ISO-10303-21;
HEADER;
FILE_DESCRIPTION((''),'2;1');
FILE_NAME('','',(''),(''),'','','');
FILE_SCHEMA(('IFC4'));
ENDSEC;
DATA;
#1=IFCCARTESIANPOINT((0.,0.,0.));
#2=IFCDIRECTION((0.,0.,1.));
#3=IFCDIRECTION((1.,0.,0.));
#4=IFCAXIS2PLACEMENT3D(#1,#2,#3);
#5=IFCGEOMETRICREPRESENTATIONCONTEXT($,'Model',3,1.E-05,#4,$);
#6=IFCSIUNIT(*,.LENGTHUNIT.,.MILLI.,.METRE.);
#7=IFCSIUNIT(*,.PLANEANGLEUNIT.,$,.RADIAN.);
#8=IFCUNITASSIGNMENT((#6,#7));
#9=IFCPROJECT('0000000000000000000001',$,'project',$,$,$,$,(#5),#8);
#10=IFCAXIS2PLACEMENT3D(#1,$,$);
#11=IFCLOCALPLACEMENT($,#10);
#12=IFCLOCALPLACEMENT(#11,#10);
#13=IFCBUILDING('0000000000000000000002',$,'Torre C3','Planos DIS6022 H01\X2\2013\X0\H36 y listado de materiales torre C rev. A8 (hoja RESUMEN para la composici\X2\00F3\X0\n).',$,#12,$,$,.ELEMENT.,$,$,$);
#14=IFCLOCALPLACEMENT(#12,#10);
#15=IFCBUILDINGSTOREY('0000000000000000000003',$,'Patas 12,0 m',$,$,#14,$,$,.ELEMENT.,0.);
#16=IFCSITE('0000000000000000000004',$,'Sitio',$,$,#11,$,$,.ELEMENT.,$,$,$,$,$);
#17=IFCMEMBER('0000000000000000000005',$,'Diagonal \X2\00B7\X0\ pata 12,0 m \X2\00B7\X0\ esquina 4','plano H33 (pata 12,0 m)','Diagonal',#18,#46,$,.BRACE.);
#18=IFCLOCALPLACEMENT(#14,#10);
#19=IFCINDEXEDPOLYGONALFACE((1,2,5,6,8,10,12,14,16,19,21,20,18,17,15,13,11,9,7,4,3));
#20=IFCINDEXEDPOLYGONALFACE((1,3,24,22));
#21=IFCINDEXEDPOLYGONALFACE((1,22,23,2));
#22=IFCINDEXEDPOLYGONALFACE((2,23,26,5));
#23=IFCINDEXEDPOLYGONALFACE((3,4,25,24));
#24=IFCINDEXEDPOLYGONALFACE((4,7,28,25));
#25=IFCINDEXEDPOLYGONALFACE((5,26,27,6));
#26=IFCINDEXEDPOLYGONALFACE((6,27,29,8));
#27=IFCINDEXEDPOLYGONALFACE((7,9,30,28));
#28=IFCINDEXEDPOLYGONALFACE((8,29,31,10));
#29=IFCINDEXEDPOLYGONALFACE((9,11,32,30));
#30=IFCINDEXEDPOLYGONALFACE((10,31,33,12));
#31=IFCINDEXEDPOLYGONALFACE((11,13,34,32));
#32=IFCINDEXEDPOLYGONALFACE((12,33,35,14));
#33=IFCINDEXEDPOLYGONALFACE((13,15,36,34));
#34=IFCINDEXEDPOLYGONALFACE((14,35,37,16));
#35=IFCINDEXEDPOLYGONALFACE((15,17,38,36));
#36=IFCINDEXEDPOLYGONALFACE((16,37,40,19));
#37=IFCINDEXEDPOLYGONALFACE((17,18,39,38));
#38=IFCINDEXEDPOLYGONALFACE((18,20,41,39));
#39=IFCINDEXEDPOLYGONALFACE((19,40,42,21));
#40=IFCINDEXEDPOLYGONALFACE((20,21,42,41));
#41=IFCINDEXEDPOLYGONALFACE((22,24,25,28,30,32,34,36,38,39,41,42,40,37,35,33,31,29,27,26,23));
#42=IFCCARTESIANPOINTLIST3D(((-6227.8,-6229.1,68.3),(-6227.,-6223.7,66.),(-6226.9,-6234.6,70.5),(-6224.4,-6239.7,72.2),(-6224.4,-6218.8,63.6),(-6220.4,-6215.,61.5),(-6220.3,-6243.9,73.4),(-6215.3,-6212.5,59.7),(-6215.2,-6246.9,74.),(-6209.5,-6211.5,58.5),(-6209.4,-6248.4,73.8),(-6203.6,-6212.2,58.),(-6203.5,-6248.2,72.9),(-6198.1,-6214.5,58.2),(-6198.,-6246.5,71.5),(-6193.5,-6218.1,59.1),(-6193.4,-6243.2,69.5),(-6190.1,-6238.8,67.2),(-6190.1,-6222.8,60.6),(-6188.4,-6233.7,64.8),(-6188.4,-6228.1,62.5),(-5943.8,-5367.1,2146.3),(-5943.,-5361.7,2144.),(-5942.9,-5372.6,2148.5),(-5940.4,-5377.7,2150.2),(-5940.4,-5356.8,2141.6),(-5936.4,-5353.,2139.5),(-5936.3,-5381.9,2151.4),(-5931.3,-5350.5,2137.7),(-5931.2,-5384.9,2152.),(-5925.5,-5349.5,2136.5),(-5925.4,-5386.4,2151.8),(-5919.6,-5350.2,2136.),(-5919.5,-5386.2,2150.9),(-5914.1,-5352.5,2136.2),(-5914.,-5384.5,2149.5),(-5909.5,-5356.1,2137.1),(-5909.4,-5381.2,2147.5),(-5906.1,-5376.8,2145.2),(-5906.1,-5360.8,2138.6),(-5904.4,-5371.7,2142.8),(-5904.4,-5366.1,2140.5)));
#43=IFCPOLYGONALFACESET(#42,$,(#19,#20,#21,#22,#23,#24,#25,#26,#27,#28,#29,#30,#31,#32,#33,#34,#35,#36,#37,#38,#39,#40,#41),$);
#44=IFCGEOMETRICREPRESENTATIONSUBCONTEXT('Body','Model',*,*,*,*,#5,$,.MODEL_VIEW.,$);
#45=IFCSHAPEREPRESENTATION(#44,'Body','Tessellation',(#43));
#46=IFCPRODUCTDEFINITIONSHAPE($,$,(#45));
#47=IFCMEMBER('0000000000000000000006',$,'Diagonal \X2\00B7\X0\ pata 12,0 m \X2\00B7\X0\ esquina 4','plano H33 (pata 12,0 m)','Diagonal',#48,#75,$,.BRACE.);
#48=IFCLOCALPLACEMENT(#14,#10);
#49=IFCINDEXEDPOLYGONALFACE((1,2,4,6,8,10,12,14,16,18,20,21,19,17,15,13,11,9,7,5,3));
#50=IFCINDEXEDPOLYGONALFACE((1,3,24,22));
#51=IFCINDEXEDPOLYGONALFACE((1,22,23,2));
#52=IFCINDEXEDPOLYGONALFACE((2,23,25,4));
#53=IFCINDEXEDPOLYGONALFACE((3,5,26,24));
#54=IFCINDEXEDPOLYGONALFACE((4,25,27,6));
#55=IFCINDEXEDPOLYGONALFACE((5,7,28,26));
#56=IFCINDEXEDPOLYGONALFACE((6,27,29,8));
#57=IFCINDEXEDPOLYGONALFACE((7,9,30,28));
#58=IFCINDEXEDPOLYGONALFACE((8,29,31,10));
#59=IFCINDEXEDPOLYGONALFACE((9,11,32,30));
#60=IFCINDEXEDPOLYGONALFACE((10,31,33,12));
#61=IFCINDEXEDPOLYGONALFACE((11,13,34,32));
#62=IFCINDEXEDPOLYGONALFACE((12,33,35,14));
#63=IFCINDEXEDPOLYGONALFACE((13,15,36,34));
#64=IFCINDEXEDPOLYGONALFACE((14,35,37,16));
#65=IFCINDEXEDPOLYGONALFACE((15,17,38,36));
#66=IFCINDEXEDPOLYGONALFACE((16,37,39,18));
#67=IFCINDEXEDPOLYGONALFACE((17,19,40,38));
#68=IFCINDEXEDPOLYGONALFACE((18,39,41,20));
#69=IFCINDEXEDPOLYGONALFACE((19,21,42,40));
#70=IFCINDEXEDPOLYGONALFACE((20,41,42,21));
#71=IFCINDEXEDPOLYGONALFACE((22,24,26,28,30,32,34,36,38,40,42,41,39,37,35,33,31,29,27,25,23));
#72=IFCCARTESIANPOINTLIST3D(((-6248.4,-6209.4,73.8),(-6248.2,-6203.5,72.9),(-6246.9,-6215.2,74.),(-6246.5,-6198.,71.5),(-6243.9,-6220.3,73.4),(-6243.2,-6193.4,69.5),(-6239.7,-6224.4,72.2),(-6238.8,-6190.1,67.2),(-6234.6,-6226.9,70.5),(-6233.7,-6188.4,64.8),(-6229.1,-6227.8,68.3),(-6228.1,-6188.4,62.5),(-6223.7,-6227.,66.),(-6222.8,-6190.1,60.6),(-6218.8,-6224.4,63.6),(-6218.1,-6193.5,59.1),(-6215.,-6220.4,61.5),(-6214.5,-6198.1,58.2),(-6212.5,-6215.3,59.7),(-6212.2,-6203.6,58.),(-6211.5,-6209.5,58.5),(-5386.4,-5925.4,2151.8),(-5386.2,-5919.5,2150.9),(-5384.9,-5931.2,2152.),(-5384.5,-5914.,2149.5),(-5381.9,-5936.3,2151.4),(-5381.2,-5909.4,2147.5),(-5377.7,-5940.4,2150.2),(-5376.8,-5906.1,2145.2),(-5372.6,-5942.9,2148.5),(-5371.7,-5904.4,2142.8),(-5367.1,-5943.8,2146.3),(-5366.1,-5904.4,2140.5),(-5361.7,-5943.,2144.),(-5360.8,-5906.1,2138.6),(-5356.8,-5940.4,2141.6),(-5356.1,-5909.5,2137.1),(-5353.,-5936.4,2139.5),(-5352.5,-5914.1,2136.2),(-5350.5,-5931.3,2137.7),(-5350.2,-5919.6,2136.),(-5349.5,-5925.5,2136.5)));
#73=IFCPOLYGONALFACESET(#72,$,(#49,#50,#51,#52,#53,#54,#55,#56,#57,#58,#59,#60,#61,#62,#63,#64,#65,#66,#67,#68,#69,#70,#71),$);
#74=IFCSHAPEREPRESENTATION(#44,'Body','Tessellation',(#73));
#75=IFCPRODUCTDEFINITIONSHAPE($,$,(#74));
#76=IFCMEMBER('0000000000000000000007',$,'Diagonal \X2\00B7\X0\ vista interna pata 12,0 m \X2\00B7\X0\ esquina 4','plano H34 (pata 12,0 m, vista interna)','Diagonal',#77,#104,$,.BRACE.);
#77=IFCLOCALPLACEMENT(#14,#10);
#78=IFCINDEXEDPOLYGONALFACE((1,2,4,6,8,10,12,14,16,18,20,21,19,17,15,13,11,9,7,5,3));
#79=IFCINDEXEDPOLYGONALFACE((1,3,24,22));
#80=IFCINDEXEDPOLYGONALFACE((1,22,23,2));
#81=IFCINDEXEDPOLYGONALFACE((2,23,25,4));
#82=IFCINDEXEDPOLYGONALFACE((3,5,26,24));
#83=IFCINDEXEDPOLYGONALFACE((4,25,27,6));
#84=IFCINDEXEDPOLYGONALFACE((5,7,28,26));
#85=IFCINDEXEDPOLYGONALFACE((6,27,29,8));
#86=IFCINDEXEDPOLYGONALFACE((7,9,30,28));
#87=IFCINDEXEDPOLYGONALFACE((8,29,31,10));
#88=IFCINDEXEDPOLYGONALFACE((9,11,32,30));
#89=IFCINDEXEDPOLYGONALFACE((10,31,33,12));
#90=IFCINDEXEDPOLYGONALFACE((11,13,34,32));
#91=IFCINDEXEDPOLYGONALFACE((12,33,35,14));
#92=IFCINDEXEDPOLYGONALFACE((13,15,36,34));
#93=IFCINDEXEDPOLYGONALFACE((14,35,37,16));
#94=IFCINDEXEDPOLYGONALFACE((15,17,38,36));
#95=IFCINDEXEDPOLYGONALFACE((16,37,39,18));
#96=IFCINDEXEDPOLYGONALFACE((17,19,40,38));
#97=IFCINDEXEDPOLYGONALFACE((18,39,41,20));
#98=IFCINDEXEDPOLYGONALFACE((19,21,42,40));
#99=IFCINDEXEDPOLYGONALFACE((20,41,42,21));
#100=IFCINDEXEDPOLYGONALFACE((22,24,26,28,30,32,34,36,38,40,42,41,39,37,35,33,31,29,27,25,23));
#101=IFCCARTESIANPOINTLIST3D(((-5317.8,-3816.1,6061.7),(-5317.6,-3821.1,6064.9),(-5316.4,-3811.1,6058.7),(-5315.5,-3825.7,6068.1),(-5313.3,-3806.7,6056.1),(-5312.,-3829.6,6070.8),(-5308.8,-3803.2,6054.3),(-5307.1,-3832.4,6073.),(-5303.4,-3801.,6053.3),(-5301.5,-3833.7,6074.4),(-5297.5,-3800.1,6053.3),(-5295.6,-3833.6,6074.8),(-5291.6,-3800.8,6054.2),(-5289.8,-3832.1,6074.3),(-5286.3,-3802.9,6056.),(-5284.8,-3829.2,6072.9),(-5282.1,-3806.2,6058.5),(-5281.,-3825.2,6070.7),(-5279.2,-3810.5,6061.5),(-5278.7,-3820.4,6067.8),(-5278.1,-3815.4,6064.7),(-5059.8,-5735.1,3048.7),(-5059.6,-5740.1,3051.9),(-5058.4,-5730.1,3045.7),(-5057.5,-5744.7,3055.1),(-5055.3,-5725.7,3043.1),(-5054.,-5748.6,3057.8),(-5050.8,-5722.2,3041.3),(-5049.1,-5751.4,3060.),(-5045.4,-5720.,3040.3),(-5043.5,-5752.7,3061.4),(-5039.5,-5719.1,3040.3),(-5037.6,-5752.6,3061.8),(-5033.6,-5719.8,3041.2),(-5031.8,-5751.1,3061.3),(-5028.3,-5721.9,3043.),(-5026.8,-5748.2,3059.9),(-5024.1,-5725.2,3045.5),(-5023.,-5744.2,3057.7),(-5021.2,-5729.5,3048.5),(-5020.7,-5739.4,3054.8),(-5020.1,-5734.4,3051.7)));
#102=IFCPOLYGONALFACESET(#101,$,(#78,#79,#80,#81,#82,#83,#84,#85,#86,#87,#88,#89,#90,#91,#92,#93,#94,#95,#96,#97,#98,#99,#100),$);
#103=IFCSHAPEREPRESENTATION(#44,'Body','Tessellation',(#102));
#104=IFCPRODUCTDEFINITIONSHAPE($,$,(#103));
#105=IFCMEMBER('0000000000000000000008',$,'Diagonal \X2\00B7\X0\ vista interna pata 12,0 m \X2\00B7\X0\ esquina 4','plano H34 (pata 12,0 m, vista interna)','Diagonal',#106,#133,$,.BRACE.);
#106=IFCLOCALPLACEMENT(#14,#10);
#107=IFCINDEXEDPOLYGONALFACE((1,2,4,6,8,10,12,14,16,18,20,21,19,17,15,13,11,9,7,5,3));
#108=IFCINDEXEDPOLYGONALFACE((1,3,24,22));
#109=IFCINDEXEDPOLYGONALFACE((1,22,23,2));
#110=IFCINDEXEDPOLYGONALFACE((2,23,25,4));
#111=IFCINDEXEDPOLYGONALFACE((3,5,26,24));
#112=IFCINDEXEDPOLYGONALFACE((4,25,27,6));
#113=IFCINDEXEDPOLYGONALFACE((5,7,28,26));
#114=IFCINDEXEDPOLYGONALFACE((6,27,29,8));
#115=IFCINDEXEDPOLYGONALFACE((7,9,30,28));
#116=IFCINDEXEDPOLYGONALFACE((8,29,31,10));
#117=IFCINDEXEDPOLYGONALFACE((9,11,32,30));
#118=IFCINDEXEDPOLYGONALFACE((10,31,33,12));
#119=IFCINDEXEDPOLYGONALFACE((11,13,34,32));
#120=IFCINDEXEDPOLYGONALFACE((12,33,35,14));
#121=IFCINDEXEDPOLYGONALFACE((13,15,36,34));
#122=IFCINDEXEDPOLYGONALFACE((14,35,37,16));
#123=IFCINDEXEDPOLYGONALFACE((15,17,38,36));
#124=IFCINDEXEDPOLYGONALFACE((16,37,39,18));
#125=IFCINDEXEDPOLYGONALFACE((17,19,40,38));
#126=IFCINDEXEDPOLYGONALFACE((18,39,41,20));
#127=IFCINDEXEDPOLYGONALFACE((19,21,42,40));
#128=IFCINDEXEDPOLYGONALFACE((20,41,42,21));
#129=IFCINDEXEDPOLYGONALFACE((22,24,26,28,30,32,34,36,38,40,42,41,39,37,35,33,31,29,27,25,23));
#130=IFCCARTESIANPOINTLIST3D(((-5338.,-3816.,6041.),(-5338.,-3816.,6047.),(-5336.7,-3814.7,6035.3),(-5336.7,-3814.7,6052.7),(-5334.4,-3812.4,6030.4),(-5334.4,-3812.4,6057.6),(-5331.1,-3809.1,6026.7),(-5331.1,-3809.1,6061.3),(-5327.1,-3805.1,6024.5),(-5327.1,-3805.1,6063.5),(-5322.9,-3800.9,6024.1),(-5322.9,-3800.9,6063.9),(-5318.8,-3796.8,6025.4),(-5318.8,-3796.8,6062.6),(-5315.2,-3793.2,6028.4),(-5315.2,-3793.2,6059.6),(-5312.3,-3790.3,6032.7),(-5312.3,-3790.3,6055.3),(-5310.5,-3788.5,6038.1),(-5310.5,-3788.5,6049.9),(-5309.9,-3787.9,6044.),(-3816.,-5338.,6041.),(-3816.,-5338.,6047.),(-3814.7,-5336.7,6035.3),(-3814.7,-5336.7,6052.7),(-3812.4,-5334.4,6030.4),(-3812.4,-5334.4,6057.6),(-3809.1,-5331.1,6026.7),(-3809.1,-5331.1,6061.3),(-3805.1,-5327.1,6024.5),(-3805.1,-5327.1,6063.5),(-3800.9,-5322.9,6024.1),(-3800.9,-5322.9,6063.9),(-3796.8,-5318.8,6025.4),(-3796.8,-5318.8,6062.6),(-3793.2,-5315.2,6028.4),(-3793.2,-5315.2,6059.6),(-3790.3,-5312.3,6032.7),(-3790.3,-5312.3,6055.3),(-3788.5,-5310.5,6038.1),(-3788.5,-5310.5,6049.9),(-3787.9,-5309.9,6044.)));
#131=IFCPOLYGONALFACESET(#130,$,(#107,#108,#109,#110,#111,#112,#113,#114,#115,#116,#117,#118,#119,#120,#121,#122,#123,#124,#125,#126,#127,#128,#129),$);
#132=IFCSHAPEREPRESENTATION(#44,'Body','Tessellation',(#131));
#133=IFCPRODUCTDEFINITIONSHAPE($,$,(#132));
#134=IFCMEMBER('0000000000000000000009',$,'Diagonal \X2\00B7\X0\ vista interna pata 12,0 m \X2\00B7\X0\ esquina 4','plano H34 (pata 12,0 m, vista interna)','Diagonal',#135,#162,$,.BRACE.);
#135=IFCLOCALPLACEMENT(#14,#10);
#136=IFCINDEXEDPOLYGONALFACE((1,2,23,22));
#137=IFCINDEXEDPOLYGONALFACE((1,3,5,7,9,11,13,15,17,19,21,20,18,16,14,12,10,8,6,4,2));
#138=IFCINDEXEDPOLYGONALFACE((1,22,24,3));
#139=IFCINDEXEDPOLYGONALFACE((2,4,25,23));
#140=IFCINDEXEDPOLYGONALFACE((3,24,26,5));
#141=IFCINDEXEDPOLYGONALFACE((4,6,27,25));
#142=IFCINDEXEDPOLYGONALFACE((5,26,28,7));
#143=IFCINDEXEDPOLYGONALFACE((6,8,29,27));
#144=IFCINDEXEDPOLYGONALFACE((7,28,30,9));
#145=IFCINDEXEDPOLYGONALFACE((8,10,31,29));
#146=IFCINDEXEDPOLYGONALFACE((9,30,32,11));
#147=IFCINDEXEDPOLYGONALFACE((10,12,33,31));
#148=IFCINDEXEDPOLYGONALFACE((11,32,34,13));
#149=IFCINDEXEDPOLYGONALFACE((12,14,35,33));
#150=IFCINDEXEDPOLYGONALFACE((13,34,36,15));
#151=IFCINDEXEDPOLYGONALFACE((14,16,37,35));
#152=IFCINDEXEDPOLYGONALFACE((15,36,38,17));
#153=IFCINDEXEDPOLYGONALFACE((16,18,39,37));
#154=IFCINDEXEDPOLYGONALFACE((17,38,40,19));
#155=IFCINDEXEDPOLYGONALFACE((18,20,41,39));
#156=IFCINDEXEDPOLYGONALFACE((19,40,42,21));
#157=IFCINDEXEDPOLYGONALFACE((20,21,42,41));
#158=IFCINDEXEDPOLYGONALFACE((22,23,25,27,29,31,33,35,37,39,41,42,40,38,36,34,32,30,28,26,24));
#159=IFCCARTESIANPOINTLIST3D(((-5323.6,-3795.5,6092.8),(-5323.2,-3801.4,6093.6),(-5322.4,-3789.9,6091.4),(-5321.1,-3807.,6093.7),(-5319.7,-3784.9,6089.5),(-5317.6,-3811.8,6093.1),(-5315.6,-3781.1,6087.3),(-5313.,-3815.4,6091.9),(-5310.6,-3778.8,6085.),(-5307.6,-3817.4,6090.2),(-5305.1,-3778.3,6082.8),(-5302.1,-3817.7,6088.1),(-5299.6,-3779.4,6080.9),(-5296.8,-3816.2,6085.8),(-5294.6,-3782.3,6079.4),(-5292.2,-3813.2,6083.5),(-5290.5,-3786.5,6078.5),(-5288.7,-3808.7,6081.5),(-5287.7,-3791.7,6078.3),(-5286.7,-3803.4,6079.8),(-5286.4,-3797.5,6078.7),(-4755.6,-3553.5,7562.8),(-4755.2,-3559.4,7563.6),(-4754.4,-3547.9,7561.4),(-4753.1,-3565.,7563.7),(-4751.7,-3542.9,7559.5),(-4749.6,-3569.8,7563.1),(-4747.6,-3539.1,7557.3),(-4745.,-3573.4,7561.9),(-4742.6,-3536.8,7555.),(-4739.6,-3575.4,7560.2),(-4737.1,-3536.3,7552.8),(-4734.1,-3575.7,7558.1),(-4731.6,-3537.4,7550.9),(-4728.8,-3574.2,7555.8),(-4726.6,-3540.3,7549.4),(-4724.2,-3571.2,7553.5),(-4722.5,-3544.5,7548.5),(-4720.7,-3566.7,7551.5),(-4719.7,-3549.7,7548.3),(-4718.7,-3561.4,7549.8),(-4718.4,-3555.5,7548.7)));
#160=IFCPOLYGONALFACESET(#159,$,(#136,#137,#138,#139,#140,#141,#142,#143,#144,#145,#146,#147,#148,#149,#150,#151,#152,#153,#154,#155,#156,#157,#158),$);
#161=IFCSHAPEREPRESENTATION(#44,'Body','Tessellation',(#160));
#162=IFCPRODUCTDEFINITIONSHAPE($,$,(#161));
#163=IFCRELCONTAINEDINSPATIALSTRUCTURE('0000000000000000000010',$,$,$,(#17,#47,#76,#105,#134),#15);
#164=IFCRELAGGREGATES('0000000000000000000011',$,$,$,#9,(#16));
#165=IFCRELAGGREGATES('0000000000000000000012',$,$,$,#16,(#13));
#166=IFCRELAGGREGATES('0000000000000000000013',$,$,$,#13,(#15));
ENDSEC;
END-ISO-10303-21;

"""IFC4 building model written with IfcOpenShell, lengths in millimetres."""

from ifc_helpers import new_model, si_unit, frame, origin, origin_with_axes, place, context, subcontext, project, spatial, circle, extrude, element, save


model = new_model("IFC4")

# Units and contexts
model_context = context("Model", 3, precision=1e-05, world=origin_with_axes())
body_context = subcontext(model_context, "Body", "Model", "MODEL_VIEW")
ifc_project = project(units=[si_unit("LENGTHUNIT", "METRE", prefix="MILLI"), si_unit("PLANEANGLEUNIT", "RADIAN")], contexts=[model_context])

# Site, building, storey
site_placement = place(None, origin())
site = spatial("IfcSite", under=ifc_project, at=site_placement, Name="Sitio", CompositionType="ELEMENT")
building_placement = place(site_placement, origin())
building = spatial("IfcBuilding", under=site, at=building_placement, Name="Torre C3", Description="Planos DIS6022 H01–H36 y listado de materiales torre C rev. A8 (hoja RESUMEN para la composición).", CompositionType="ELEMENT")
storey_placement = place(building_placement, origin())
storey = spatial("IfcBuildingStorey", under=building, at=storey_placement, Name="Patas 12,0 m", CompositionType="ELEMENT", Elevation=0.0)

# Members
for number, where, z_axis, x_axis, name in (
    (1, (-5924.0, -5368.0, 2144.0), (-0.125245, -0.380146, -0.916407), (0.725353, 0.595105, -0.345996), "Diagonal · pata 12,0 m · esquina 4"),
    (2, (-5368.0, -5924.0, 2144.0), (-0.380146, -0.125245, -0.916407), (0.595105, 0.725353, -0.345996), "Diagonal · pata 12,0 m · esquina 4"),
):
    element("IfcMember", number, at=place(storey_placement, frame(where, z_axis=z_axis, x_axis=x_axis)), inside=storey, Name=name, Description="plano H33 (pata 12,0 m)", ObjectType="Diagonal", PredefinedType="BRACE", context=body_context, shape_type="SweptSolid", body=[
        extrude(circle(Radius=20.0), None, (0.0, 0.0, 1.0), 2267.6),
    ])
member_1_placement = place(storey_placement, frame((-5298.0, -3817.0, 6064.0), z_axis=(0.072036, -0.535806, -0.841263), x_axis=(0.79624, 0.538856, -0.27502)))
element("IfcMember", 3, at=member_1_placement, inside=storey, Name="Diagonal · vista interna pata 12,0 m · esquina 4", Description="plano H34 (pata 12,0 m, vista interna)", ObjectType="Diagonal", PredefinedType="BRACE", context=body_context, shape_type="SweptSolid", body=[
    extrude(circle(Radius=20.0), None, (0.0, 0.0, 1.0), 3581.5),
])
member_2_placement = place(storey_placement, frame((-5324.0, -3802.0, 6044.0), z_axis=(0.707107, -0.707107, 0.0), x_axis=(0.707107, 0.707107, 0.0)))
element("IfcMember", 4, at=member_2_placement, inside=storey, Name="Diagonal · vista interna pata 12,0 m · esquina 4", Description="plano H34 (pata 12,0 m, vista interna)", ObjectType="Diagonal", PredefinedType="BRACE", context=body_context, shape_type="SweptSolid", body=[
    extrude(circle(Radius=20.0), None, (0.0, 0.0, 1.0), 2152.4),
])
member_3_placement = place(storey_placement, frame((-5305.0, -3798.0, 6086.0), z_axis=(0.356249, 0.151782, 0.921981), x_axis=(0.726055, 0.576131, -0.37539)))
element("IfcMember", 5, at=member_3_placement, inside=storey, Name="Diagonal · vista interna pata 12,0 m · esquina 4", Description="plano H34 (pata 12,0 m, vista interna)", ObjectType="Diagonal", PredefinedType="BRACE", context=body_context, shape_type="SweptSolid", body=[
    extrude(circle(Radius=20.0), None, (0.0, 0.0, 1.0), 1594.4),
])

save(model, "model.ifc")
